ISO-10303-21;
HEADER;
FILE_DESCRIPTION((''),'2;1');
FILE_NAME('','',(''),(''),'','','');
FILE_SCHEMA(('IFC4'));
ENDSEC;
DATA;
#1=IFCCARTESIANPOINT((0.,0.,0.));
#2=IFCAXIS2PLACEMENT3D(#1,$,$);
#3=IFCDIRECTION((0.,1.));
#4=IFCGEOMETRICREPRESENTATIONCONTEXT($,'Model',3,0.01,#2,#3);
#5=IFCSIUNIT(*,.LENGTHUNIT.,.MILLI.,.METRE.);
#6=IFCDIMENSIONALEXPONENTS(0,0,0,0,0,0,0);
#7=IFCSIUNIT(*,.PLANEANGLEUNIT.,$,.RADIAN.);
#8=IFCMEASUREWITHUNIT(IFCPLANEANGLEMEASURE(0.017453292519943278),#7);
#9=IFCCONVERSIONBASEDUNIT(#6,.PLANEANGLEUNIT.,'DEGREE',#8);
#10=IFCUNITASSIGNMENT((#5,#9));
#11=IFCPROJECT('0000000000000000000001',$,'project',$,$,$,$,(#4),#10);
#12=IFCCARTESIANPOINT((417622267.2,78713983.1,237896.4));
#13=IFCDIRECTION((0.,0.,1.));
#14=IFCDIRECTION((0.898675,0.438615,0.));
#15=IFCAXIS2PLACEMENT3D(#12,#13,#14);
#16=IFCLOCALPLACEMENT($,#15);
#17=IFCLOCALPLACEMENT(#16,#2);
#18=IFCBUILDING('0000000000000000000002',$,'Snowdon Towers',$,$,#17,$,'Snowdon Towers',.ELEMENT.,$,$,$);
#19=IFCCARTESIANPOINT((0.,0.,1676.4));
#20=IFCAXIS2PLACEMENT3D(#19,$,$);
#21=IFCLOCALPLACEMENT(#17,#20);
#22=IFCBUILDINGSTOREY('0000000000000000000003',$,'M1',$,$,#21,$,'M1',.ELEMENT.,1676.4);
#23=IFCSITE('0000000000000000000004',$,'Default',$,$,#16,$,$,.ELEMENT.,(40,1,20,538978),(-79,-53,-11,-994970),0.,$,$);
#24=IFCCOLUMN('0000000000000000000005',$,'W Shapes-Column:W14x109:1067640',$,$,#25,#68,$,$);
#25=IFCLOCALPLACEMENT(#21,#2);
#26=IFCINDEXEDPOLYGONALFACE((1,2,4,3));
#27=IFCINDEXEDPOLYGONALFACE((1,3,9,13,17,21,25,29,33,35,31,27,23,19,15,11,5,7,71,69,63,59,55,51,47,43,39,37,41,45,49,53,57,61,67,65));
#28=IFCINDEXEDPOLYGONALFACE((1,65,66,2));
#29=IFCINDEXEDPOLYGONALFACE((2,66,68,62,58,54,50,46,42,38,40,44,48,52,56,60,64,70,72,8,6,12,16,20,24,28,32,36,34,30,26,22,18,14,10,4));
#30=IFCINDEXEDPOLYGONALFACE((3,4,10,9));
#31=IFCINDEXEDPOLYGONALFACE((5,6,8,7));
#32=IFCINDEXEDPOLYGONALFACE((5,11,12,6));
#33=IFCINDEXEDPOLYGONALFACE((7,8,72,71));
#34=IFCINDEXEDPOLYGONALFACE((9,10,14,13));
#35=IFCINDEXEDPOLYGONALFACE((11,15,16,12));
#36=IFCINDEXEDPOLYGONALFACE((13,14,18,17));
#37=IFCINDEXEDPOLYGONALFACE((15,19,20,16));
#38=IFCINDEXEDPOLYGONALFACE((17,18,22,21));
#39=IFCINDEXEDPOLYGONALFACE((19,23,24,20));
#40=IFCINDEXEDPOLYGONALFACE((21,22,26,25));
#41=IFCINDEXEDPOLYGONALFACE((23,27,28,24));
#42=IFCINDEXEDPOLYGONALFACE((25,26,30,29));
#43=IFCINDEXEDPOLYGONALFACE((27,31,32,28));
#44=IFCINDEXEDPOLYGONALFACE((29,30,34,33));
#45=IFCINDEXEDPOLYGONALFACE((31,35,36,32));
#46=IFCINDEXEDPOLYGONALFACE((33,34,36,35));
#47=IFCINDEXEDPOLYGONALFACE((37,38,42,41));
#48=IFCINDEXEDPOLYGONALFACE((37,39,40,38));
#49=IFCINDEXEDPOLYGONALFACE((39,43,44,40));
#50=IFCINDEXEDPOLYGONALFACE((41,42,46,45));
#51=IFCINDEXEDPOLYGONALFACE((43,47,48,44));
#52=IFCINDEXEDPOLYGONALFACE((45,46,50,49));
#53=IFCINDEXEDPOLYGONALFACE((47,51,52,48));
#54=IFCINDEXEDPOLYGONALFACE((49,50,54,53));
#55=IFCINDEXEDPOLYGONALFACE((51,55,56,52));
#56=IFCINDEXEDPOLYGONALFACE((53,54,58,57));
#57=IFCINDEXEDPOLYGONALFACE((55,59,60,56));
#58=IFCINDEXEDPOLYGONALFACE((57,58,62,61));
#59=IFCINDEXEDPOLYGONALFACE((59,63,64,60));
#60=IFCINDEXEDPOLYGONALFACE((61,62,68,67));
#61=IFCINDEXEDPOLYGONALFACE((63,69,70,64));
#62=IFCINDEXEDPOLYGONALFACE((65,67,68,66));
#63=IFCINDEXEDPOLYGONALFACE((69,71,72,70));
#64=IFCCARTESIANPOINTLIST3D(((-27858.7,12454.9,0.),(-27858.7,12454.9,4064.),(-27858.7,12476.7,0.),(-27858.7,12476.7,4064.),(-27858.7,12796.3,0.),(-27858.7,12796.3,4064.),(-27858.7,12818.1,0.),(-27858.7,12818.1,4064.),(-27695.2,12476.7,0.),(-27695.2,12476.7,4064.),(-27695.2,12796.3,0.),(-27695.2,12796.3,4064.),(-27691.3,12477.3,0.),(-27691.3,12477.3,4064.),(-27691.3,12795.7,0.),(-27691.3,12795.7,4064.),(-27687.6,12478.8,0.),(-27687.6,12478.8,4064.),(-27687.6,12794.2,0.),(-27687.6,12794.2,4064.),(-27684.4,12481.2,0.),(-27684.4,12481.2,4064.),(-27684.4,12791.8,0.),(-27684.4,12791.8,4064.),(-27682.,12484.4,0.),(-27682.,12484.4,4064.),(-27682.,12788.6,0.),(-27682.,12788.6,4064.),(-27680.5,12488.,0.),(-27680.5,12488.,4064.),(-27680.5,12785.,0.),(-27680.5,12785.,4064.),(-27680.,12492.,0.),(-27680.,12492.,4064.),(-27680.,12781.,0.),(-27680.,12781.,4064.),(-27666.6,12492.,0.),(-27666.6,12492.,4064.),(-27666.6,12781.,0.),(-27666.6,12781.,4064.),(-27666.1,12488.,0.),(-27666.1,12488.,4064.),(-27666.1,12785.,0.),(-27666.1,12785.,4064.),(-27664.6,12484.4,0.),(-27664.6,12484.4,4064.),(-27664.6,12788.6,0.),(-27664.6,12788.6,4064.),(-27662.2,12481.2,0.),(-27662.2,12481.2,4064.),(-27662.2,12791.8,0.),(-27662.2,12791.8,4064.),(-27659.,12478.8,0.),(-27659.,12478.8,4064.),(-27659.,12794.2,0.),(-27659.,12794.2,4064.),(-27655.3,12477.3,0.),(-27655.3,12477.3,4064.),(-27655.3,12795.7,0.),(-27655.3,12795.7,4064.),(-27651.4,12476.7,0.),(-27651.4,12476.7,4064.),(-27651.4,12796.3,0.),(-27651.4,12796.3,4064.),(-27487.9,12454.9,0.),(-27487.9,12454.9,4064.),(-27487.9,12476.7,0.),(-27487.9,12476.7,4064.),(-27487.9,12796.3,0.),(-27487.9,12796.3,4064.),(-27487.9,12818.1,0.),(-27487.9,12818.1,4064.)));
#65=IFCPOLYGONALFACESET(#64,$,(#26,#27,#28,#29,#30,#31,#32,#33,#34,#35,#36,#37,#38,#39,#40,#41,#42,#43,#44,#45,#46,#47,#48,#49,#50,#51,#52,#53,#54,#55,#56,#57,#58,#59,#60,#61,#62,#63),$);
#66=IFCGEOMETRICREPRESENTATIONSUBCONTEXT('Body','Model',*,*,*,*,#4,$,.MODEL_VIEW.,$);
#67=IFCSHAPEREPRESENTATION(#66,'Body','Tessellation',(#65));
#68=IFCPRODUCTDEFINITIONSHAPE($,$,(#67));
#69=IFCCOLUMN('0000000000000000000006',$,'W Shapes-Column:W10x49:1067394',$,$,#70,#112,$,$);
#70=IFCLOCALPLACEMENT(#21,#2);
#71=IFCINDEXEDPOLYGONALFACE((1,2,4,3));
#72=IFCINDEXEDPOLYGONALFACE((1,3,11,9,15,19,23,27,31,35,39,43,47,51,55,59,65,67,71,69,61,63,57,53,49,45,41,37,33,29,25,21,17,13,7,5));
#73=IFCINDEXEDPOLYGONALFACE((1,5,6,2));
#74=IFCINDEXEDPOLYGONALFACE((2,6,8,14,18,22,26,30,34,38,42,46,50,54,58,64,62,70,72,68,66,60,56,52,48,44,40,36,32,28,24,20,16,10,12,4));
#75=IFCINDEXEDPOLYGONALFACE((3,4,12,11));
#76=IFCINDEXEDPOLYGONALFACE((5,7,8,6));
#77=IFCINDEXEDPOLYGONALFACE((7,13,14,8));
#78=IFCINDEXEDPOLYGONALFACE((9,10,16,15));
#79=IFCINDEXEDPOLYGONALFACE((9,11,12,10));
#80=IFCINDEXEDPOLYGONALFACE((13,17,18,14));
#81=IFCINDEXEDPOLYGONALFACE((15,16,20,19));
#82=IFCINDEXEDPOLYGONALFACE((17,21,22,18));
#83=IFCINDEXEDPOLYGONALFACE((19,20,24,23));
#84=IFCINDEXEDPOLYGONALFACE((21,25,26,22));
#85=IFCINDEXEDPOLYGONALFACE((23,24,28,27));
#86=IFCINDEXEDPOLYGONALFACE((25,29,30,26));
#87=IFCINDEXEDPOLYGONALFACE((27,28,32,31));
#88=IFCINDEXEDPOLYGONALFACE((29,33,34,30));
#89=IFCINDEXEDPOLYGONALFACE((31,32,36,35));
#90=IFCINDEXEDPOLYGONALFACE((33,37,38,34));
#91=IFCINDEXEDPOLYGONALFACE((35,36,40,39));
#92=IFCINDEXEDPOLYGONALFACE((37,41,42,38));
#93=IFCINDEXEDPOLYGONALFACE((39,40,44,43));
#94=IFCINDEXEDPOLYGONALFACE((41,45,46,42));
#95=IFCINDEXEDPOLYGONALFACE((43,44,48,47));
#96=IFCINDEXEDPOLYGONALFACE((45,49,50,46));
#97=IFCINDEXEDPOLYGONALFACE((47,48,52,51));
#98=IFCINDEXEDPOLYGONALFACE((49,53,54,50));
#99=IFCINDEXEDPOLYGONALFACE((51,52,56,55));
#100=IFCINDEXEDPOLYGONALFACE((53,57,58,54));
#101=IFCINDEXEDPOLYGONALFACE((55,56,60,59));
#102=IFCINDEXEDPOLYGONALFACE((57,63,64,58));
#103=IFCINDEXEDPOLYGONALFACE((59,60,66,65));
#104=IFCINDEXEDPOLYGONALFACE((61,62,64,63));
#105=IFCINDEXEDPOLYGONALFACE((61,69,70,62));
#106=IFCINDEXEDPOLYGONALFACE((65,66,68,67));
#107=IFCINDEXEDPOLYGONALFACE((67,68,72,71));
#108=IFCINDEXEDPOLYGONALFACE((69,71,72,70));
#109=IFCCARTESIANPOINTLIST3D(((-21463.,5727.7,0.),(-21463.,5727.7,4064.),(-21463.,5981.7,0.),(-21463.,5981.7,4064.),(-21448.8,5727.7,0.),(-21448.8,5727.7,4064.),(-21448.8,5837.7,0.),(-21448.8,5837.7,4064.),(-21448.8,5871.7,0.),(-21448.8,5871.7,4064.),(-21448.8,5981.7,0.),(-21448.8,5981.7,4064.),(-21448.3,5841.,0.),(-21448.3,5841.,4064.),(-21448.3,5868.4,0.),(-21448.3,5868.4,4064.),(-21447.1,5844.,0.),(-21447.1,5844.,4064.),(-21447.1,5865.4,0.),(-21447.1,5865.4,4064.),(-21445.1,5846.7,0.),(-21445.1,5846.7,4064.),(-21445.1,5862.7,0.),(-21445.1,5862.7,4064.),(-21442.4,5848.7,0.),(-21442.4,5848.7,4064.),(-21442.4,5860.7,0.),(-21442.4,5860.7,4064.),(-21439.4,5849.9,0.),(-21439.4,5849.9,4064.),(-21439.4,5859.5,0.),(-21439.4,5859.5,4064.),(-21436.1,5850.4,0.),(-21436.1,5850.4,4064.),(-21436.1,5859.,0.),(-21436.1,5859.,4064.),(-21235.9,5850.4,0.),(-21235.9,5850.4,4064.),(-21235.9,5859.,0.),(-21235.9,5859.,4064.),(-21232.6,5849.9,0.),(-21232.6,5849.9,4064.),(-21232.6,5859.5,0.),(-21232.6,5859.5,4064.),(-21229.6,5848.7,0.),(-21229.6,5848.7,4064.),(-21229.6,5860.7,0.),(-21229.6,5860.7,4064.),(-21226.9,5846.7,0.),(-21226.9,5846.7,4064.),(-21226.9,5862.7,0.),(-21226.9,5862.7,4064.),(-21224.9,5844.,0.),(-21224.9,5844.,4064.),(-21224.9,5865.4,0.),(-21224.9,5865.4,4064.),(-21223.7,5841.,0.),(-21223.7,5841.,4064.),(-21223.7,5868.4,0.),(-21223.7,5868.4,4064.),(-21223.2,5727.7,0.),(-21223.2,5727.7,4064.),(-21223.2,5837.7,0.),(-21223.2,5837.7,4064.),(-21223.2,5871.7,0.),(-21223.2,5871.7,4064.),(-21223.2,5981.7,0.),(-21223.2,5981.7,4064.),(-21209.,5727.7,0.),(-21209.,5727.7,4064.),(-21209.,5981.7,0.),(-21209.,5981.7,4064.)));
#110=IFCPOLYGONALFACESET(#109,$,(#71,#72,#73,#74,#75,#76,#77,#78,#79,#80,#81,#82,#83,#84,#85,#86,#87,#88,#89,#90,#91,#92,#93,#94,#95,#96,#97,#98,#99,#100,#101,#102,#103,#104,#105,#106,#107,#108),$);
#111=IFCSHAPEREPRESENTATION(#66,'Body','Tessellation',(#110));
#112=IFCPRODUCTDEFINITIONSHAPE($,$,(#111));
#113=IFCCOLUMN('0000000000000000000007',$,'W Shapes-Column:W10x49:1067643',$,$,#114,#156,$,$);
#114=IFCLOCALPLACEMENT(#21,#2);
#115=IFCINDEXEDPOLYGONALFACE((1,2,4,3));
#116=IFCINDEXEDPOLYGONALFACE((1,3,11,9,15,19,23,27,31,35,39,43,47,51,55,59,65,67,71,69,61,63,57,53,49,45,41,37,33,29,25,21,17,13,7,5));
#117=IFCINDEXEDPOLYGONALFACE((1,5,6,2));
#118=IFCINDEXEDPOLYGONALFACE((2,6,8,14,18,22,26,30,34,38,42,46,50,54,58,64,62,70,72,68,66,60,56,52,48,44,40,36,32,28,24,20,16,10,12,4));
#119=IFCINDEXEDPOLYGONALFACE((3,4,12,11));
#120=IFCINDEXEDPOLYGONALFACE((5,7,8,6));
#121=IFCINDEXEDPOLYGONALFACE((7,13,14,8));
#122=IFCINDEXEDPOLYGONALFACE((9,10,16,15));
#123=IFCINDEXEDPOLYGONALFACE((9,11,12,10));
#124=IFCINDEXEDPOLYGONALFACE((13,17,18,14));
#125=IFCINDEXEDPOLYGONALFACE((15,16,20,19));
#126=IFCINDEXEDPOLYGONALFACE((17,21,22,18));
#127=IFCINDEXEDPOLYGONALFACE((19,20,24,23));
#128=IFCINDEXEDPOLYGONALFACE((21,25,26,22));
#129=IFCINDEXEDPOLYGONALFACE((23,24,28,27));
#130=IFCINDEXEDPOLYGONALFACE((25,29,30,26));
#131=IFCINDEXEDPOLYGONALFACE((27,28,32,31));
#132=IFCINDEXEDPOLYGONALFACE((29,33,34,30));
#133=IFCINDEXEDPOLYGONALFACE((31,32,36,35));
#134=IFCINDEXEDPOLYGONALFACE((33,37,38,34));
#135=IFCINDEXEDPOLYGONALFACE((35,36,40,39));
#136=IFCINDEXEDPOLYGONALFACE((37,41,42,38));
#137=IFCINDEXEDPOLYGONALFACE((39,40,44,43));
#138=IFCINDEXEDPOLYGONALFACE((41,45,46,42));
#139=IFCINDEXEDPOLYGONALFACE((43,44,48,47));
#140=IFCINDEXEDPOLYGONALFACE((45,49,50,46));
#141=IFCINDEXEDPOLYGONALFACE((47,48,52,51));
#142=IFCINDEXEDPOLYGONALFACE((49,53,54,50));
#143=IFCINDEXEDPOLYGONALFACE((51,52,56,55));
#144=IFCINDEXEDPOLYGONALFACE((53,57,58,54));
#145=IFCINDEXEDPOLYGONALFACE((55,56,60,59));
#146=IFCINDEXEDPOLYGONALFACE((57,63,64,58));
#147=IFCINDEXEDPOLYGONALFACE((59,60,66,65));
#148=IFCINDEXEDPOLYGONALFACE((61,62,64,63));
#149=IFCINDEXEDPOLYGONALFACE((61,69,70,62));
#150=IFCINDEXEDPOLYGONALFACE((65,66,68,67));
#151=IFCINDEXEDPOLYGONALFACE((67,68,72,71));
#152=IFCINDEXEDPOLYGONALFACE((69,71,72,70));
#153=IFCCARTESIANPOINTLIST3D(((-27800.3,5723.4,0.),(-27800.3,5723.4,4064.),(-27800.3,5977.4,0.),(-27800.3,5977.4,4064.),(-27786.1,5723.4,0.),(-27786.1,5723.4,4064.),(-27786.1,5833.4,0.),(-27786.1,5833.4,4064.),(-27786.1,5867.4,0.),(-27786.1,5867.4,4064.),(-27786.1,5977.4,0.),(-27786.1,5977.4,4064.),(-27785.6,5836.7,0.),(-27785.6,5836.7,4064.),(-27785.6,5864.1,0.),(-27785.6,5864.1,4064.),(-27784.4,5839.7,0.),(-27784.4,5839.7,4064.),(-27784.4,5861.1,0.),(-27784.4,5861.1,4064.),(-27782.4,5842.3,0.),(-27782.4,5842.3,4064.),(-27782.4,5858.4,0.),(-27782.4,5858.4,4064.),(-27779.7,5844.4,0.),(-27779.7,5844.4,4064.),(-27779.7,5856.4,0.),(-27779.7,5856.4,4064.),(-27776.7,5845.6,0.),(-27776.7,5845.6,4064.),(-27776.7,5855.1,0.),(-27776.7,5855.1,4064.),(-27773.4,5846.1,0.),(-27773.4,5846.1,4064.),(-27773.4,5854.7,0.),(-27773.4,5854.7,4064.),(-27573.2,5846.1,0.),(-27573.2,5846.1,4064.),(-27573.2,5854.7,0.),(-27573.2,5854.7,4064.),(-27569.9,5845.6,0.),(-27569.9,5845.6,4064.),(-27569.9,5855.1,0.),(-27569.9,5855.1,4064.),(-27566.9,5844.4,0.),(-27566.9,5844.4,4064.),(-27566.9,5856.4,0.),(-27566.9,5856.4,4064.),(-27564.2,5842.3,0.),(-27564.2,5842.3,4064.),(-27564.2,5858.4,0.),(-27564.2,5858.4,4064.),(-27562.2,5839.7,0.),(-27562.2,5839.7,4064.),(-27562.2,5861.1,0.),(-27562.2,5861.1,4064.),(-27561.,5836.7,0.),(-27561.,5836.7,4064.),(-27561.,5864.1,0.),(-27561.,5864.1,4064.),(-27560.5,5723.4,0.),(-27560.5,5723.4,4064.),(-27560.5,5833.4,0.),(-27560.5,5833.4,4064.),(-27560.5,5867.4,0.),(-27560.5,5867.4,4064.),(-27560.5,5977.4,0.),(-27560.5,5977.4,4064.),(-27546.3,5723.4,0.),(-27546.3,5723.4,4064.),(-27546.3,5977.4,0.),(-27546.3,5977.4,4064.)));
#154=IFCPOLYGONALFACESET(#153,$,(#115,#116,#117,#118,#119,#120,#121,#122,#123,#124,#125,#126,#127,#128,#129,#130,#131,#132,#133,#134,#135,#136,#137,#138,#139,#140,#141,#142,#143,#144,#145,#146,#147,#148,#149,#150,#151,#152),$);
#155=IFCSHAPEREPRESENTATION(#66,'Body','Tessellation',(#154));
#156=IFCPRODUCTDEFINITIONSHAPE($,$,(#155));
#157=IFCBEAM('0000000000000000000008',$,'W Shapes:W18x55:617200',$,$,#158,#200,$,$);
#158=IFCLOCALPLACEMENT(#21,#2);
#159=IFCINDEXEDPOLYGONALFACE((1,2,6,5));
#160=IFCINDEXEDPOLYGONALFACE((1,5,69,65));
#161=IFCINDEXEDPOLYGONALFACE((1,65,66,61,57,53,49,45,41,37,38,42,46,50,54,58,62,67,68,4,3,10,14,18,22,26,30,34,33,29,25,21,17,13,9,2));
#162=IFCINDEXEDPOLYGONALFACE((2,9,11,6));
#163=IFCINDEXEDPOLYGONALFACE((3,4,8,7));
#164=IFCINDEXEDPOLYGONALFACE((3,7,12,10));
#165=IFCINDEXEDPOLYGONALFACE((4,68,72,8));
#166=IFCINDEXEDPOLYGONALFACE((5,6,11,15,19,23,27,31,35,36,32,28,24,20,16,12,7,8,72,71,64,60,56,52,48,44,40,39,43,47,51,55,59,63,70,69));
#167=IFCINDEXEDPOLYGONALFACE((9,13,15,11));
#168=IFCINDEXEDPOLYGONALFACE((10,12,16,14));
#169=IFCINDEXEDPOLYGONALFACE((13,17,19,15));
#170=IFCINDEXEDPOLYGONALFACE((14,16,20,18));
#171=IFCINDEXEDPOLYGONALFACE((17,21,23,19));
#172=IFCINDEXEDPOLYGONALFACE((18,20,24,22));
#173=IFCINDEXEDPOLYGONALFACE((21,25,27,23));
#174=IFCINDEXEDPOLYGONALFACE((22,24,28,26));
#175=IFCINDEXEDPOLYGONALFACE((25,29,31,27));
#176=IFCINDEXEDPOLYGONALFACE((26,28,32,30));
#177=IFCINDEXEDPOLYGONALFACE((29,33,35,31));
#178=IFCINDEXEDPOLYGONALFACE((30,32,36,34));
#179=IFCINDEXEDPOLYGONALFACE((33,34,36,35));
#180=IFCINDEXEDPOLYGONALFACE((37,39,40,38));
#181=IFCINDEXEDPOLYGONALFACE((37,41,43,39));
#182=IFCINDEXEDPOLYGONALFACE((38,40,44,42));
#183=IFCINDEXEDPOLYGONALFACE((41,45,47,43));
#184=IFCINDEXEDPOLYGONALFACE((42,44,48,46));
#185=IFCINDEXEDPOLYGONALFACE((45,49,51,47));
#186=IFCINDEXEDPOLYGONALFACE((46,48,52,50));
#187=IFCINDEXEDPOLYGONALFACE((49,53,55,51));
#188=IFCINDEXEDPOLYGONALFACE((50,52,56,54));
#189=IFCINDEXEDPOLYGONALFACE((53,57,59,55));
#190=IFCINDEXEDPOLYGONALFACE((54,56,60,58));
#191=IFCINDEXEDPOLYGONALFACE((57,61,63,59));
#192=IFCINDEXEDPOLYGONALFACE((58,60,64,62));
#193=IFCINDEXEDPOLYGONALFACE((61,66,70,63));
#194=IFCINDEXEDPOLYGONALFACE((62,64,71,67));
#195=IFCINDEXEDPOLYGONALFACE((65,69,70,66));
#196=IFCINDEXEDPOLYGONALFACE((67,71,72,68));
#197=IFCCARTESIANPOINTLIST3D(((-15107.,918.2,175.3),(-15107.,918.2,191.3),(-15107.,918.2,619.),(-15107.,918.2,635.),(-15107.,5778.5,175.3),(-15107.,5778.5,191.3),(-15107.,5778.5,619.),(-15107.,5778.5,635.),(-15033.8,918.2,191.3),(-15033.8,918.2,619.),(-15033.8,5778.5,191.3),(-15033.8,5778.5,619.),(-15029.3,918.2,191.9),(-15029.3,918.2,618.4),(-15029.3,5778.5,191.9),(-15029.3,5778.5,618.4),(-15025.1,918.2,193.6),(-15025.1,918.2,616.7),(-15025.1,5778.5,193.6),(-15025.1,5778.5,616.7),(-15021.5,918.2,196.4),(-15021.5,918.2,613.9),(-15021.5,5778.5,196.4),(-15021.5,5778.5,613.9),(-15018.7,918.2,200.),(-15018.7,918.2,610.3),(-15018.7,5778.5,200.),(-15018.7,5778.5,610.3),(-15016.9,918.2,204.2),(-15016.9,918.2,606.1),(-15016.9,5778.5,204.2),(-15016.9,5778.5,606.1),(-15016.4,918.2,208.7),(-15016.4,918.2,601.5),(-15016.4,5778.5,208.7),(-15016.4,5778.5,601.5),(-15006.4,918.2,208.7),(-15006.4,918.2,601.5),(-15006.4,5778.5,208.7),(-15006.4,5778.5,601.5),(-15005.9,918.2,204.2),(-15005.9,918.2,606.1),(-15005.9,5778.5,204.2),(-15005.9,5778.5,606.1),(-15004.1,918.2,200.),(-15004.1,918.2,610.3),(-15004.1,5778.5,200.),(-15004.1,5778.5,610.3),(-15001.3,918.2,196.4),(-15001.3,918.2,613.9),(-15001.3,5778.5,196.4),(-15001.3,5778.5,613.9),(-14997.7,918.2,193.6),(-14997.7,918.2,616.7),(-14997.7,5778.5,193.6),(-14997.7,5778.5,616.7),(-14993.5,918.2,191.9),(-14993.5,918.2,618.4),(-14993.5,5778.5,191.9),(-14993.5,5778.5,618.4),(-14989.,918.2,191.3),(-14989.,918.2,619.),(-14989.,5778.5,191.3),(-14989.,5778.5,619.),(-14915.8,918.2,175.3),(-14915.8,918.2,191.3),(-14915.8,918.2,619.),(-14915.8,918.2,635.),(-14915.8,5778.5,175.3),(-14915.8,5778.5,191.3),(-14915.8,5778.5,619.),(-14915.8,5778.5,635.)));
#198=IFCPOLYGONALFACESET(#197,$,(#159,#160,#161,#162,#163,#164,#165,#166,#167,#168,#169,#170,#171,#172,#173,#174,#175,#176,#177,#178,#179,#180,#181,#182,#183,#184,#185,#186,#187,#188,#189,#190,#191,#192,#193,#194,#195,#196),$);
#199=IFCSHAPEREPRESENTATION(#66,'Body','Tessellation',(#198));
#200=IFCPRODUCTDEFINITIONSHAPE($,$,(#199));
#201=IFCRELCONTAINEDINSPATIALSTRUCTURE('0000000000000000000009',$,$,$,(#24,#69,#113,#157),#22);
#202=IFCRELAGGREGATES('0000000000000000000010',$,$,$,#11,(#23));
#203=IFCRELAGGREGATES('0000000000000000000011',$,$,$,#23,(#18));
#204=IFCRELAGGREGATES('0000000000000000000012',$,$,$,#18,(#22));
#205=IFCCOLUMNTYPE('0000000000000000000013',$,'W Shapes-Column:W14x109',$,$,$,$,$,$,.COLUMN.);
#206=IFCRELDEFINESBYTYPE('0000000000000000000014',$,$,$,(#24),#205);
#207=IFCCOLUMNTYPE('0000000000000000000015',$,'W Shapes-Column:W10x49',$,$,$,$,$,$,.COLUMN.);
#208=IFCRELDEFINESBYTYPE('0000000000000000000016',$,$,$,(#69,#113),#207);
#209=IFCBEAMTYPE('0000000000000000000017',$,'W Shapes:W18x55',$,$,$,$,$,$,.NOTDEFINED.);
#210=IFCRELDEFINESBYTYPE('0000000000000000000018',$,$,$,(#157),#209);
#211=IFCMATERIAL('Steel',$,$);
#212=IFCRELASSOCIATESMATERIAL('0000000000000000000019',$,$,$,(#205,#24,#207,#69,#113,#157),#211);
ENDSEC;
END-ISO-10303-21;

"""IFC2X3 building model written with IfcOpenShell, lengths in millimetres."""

from ifc_helpers import new_model, entity, si_unit, converted_unit, direction, frame, frame_2d, origin, place, context, subcontext, project, spatial, i_section, extrude, source, transform, mapped, material, type_object, type_shapes, element, save


model = new_model("IFC2X3")

# Units and contexts
model_context = context("Model", 3, precision=0.01, world=origin(), true_north=direction((0.0, 1.0)))
body_context = subcontext(model_context, "Body", "Model", "MODEL_VIEW")
ifc_project = project(units=[si_unit("LENGTHUNIT", "METRE", prefix="MILLI"), converted_unit("PLANEANGLEUNIT", "DEGREE", entity("IfcPlaneAngleMeasure", 0.017453292519943278), si_unit("PLANEANGLEUNIT", "RADIAN"), dimensions=[0, 0, 0, 0, 0, 0, 0])], contexts=[model_context])

# Site, building, storey
site_placement = place(None, frame((417622267.2, 78713983.1, 237896.4), z_axis=(0.0, 0.0, 1.0), x_axis=(0.898675, 0.438615, 0.0)))
site = spatial("IfcSite", under=ifc_project, at=site_placement, Name="Default", CompositionType="ELEMENT", RefLatitude=(40, 1, 20, 538978), RefLongitude=(-79, -53, -11, -994970), RefElevation=0.0)
building_placement = place(site_placement, origin())
building = spatial("IfcBuilding", under=site, at=building_placement, Name="Snowdon Towers", LongName="Snowdon Towers", CompositionType="ELEMENT")
storey_placement = place(building_placement, frame((0.0, 0.0, 1676.4)))
storey = spatial("IfcBuildingStorey", under=building, at=storey_placement, Name="M1", LongName="M1", CompositionType="ELEMENT", Elevation=1676.4)

# Columns
ifc_material_1 = material(Name="Steel")
column_type_1 = type_object("IfcColumnType", Name="W Shapes-Column:W14x109", PredefinedType="COLUMN", material=ifc_material_1)
shared_shape_1 = source(origin(), body_context, "Body", "SweptSolid", [
    extrude(i_section(OverallWidth=370.8, OverallDepth=363.2, WebThickness=13.3, FlangeThickness=21.8, FilletRadius=15.2, at=frame_2d((0.0, 0.0), x_axis=(1.0, 0.0))), frame((0.0, 0.0, 1676.4), z_axis=(0.0, 0.0, 1.0), x_axis=(-1.0, 0.0, 0.0)), (0.0, 0.0, 1.0), 4064.0),
])
type_shapes(column_type_1, [shared_shape_1])
for number, where, z_axis, x_axis, name in (
    (1, (-27673.3, 12636.5, -1676.4), (0.0, 0.0, 1.0), (-1.0, 0.0, 0.0), "W Shapes-Column:W14x109:1067640"),
):
    element("IfcColumn", number, at=place(storey_placement, frame(where, z_axis=z_axis, x_axis=x_axis)), inside=storey, type_object=column_type_1, material=ifc_material_1, Name=name, context=body_context, shape_type="MappedRepresentation", body=[
        mapped(shared_shape_1, transform((0.0, 0.0, 0.0), scale=1.0)),
    ])
column_type_2 = type_object("IfcColumnType", Name="W Shapes-Column:W10x49", PredefinedType="COLUMN", material=ifc_material_1)
shared_shape_2 = source(origin(), body_context, "Body", "SweptSolid", [
    extrude(i_section(OverallWidth=254.0, OverallDepth=254.0, WebThickness=8.6, FlangeThickness=14.2, FilletRadius=12.7, at=frame_2d((0.0, 0.0), x_axis=(1.0, 0.0))), frame((0.0, 0.0, 1676.4), z_axis=(0.0, 0.0, 1.0), x_axis=(-1.0, 0.0, 0.0)), (0.0, 0.0, 1.0), 4064.0),
])
type_shapes(column_type_2, [shared_shape_2])
for number, where, z_axis, x_axis, name in (
    (2, (-21336.0, 5854.7, -1676.4), (0.0, 0.0, 1.0), (0.0, 1.0, 0.0), "W Shapes-Column:W10x49:1067394"),
    (3, (-27673.3, 5850.4, -1676.4), (0.0, 0.0, 1.0), (0.0, 1.0, 0.0), "W Shapes-Column:W10x49:1067643"),
):
    element("IfcColumn", number, at=place(storey_placement, frame(where, z_axis=z_axis, x_axis=x_axis)), inside=storey, type_object=column_type_2, material=ifc_material_1, Name=name, context=body_context, shape_type="MappedRepresentation", body=[
        mapped(shared_shape_2, transform((0.0, 0.0, 0.0), scale=1.0)),
    ])

# Beam
beam_type_1 = type_object("IfcBeamType", Name="W Shapes:W18x55", PredefinedType="NOTDEFINED")
beam_1_placement = place(storey_placement, frame((-15011.4, 762.0, 635.0), z_axis=(0.0, 0.0, 1.0), x_axis=(0.0, 1.0, 0.0)))
element("IfcBeam", 4, at=beam_1_placement, inside=storey, type_object=beam_type_1, material=ifc_material_1, Name="W Shapes:W18x55:617200", context=body_context, shape_type="SweptSolid", body=[
    extrude(i_section(OverallWidth=191.3, OverallDepth=459.7, WebThickness=9.9, FlangeThickness=16.0, FilletRadius=17.5, at=frame_2d((0.0, 0.0), x_axis=(0.0, 1.0))), frame((156.2, 0.0, -229.9), z_axis=(1.0, 0.0, 0.0), x_axis=(0.0, 0.0, -1.0)), (0.0, 0.0, 1.0), 4860.3),
])

save(model, "model.ifc")
